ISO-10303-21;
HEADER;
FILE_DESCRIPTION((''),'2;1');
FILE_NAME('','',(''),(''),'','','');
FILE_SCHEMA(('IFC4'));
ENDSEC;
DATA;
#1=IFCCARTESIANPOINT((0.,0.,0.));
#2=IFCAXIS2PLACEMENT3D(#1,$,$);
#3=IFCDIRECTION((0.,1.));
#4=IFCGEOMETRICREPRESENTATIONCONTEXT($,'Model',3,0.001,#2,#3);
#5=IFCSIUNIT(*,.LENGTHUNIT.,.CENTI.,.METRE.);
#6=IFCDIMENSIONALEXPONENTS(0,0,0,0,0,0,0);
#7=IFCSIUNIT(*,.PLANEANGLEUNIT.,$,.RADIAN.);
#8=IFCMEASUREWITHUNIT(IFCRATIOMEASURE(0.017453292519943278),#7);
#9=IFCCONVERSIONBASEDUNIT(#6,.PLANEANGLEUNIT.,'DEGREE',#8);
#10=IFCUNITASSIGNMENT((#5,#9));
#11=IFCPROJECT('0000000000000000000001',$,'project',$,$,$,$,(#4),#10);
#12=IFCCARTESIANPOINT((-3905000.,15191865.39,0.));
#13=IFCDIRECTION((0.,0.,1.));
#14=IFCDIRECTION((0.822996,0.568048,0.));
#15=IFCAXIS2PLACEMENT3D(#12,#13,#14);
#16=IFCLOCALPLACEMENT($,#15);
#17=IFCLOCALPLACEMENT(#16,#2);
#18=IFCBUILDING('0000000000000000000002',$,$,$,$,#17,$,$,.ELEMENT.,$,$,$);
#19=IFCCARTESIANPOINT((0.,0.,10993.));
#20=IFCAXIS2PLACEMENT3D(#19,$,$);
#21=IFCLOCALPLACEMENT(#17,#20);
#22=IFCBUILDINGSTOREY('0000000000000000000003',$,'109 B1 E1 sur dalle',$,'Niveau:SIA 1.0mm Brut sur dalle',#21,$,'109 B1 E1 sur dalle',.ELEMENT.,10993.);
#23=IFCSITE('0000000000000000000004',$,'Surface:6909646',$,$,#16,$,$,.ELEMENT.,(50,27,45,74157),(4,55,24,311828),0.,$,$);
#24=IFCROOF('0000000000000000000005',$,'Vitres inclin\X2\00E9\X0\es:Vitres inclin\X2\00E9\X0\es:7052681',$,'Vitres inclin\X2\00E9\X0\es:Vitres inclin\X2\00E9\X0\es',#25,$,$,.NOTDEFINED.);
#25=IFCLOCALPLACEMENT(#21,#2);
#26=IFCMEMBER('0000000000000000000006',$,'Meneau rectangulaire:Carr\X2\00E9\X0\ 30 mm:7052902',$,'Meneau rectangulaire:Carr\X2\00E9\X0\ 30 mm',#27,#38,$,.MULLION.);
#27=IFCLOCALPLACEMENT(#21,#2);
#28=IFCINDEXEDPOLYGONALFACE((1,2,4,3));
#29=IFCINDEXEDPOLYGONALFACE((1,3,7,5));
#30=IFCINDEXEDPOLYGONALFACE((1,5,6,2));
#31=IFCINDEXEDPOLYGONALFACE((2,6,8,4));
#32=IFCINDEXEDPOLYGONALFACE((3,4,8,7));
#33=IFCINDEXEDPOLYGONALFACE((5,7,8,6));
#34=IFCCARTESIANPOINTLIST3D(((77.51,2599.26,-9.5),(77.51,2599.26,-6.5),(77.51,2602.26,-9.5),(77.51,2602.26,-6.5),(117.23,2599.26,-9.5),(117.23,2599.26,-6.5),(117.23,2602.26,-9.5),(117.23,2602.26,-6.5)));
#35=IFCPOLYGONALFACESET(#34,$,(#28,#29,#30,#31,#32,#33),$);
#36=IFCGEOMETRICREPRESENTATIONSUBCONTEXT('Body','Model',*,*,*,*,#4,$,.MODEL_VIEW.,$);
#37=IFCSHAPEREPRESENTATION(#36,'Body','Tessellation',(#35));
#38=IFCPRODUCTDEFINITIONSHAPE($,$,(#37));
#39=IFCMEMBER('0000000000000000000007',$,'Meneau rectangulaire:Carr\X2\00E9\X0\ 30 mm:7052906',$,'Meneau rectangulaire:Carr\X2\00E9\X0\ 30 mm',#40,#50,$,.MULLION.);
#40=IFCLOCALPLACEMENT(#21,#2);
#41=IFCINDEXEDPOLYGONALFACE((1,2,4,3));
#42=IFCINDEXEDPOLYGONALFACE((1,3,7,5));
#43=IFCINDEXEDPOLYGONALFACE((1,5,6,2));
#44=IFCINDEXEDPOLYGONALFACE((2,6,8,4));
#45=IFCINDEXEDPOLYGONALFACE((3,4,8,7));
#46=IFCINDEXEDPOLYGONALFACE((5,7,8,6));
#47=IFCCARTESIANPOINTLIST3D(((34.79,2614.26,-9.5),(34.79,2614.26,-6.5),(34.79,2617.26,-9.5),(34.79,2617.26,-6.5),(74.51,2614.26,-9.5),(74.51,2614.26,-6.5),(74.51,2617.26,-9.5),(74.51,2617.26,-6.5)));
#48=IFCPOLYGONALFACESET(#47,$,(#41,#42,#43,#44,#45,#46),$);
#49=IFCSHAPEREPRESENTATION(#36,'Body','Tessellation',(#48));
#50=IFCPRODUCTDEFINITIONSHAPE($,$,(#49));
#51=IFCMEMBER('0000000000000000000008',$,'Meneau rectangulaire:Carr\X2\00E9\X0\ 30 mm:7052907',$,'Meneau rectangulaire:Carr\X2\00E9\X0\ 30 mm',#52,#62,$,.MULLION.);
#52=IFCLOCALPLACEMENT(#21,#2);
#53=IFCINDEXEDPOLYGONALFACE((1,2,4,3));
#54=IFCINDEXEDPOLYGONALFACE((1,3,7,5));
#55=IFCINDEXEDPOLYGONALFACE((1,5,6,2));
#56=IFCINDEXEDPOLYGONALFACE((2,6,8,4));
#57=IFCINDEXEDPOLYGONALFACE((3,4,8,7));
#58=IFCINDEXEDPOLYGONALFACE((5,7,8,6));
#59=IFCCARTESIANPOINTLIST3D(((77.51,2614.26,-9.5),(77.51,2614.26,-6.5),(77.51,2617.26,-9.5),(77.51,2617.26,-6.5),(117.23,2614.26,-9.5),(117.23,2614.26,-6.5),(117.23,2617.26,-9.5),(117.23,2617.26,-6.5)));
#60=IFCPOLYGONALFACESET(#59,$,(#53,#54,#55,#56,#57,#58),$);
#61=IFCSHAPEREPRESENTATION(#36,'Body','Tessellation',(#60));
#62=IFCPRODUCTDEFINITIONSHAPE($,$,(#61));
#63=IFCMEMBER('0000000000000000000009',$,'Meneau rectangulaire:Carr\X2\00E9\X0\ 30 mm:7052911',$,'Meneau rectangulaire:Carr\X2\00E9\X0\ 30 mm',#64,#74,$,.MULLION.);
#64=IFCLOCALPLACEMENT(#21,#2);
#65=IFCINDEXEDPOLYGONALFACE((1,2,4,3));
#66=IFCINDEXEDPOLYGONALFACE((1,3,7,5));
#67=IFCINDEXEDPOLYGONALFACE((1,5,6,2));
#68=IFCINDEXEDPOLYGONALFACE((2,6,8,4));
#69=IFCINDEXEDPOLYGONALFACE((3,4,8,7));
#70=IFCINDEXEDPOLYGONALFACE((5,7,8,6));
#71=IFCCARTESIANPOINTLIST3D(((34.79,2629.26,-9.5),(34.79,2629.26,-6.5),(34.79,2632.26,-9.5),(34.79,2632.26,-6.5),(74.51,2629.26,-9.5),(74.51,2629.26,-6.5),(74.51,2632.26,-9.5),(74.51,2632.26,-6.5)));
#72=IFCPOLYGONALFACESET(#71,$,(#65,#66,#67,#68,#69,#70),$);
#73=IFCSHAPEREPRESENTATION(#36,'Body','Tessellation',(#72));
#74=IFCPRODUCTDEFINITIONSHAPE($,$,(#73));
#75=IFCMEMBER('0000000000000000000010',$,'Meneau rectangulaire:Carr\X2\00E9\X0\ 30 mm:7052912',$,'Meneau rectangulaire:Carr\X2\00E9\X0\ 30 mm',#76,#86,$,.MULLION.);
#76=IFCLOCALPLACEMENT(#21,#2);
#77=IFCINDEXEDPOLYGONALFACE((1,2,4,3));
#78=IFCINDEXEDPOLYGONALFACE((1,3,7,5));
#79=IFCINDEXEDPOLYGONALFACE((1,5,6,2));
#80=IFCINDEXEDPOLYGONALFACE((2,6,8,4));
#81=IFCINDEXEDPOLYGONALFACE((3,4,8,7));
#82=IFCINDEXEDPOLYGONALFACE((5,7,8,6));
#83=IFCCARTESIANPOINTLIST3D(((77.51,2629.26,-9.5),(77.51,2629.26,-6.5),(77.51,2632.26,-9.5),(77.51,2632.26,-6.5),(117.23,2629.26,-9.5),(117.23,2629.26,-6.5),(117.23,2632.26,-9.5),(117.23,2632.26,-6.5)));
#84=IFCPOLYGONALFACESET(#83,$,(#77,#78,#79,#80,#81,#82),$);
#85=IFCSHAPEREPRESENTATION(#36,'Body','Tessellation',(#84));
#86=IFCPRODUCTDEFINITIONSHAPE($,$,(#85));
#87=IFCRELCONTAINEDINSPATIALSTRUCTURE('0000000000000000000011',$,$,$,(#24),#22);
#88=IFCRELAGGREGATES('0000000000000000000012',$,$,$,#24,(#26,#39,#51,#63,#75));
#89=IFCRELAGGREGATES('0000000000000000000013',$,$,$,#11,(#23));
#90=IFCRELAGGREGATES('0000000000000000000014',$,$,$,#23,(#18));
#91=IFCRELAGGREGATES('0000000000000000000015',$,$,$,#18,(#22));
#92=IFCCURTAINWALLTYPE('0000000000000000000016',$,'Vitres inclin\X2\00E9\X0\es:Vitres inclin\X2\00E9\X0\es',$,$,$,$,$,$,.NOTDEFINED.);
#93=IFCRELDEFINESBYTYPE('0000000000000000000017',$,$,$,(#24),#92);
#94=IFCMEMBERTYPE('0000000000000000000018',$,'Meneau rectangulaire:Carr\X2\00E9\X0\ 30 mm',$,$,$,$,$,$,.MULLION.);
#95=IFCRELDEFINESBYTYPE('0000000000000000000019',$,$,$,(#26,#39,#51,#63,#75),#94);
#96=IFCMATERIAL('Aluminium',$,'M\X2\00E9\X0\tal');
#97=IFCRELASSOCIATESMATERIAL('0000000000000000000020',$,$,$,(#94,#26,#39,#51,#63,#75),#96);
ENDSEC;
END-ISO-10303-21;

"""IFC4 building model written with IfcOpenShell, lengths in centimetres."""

from ifc_helpers import new_model, entity, si_unit, converted_unit, direction, frame, origin, place, context, subcontext, project, spatial, indexed_curve, outline, extrude, source, transform, mapped, material, type_object, type_shapes, element, aggregate, save


model = new_model("IFC4")

# Units and contexts
model_context = context("Model", 3, precision=0.001, world=origin(), true_north=direction((0.0, 1.0)))
body_context = subcontext(model_context, "Body", "Model", "MODEL_VIEW")
ifc_project = project(units=[si_unit("LENGTHUNIT", "METRE", prefix="CENTI"), converted_unit("PLANEANGLEUNIT", "DEGREE", entity("IfcRatioMeasure", 0.017453292519943278), si_unit("PLANEANGLEUNIT", "RADIAN"), dimensions=[0, 0, 0, 0, 0, 0, 0])], contexts=[model_context])

# Site, building, storey
site_placement = place(None, frame((-3905000.0, 15191865.39, 0.0), z_axis=(0.0, 0.0, 1.0), x_axis=(0.822996, 0.568048, 0.0)))
site = spatial("IfcSite", under=ifc_project, at=site_placement, Name="Surface:6909646", CompositionType="ELEMENT", RefLatitude=(50, 27, 45, 74157), RefLongitude=(4, 55, 24, 311828), RefElevation=0.0)
building_placement = place(site_placement, origin())
building = spatial("IfcBuilding", under=site, at=building_placement, CompositionType="ELEMENT")
storey_placement = place(building_placement, frame((0.0, 0.0, 10993.0)))
storey = spatial("IfcBuildingStorey", under=building, at=storey_placement, Name="109 B1 E1 sur dalle", ObjectType="Niveau:SIA 1.0mm Brut sur dalle", LongName="109 B1 E1 sur dalle", CompositionType="ELEMENT", Elevation=10993.0)

# Roof, members
curtain_wall_type = type_object("IfcCurtainWallType", Name="Vitres inclinées:Vitres inclinées", PredefinedType="NOTDEFINED")
roof_placement = place(storey_placement, frame((0.0, 0.0, -10993.0)))
roof = element("IfcRoof", 1, at=roof_placement, inside=storey, type_object=curtain_wall_type, Name="Vitres inclinées:Vitres inclinées:7052681", ObjectType="Vitres inclinées:Vitres inclinées", PredefinedType="NOTDEFINED")
ifc_material = material(Name="Aluminium", Category="Métal")
member_type_1 = type_object("IfcMemberType", Name="Meneau rectangulaire:Carré 30 mm", PredefinedType="MULLION", material=ifc_material)
shared_shape_1 = source(origin(), body_context, "Body", "SweptSolid", [
    extrude(outline(indexed_curve([(-1.5, -1.5), (1.5, -1.5), (1.5, 1.5), (-1.5, 1.5), (-1.5, -1.5)], self_intersect=False)), frame((0.0, 0.0, -39.72), z_axis=(0.0, 0.0, 1.0), x_axis=(0.0, -1.0, 0.0)), (0.0, 0.0, 1.0), 39.72),
])
type_shapes(member_type_1, [shared_shape_1])
member_1_placement = place(roof_placement, frame((77.51, 2600.76, 10985.0), z_axis=(-1.0, 0.0, 0.0), x_axis=(0.0, 1.0, 0.0)))
member_1 = element("IfcMember", 2, at=member_1_placement, type_object=member_type_1, material=ifc_material, Name="Meneau rectangulaire:Carré 30 mm:7052902", ObjectType="Meneau rectangulaire:Carré 30 mm", PredefinedType="MULLION", context=body_context, shape_type="MappedRepresentation", body=[
    mapped(shared_shape_1, transform((0.0, 0.0, 0.0), scale=1.0)),
])
member_2_placement = place(roof_placement, frame((34.79, 2615.76, 10985.0), z_axis=(-1.0, 0.0, 0.0), x_axis=(0.0, 1.0, 0.0)))
member_2 = element("IfcMember", 3, at=member_2_placement, type_object=member_type_1, material=ifc_material, Name="Meneau rectangulaire:Carré 30 mm:7052906", ObjectType="Meneau rectangulaire:Carré 30 mm", PredefinedType="MULLION", context=body_context, shape_type="MappedRepresentation", body=[
    mapped(shared_shape_1, transform((0.0, 0.0, 0.0), scale=1.0)),
])
member_3_placement = place(roof_placement, frame((77.51, 2615.76, 10985.0), z_axis=(-1.0, 0.0, 0.0), x_axis=(0.0, 1.0, 0.0)))
member_3 = element("IfcMember", 4, at=member_3_placement, type_object=member_type_1, material=ifc_material, Name="Meneau rectangulaire:Carré 30 mm:7052907", ObjectType="Meneau rectangulaire:Carré 30 mm", PredefinedType="MULLION", context=body_context, shape_type="MappedRepresentation", body=[
    mapped(shared_shape_1, transform((0.0, 0.0, 0.0), scale=1.0)),
])
member_4_placement = place(roof_placement, frame((34.79, 2630.76, 10985.0), z_axis=(-1.0, 0.0, 0.0), x_axis=(0.0, 1.0, 0.0)))
member_4 = element("IfcMember", 5, at=member_4_placement, type_object=member_type_1, material=ifc_material, Name="Meneau rectangulaire:Carré 30 mm:7052911", ObjectType="Meneau rectangulaire:Carré 30 mm", PredefinedType="MULLION", context=body_context, shape_type="MappedRepresentation", body=[
    mapped(shared_shape_1, transform((0.0, 0.0, 0.0), scale=1.0)),
])
member_5_placement = place(roof_placement, frame((77.51, 2630.76, 10985.0), z_axis=(-1.0, 0.0, 0.0), x_axis=(0.0, 1.0, 0.0)))
member_5 = element("IfcMember", 6, at=member_5_placement, type_object=member_type_1, material=ifc_material, Name="Meneau rectangulaire:Carré 30 mm:7052912", ObjectType="Meneau rectangulaire:Carré 30 mm", PredefinedType="MULLION", context=body_context, shape_type="MappedRepresentation", body=[
    mapped(shared_shape_1, transform((0.0, 0.0, 0.0), scale=1.0)),
])
aggregate(roof, [member_1, member_2, member_3, member_4, member_5])

save(model, "model.ifc")
